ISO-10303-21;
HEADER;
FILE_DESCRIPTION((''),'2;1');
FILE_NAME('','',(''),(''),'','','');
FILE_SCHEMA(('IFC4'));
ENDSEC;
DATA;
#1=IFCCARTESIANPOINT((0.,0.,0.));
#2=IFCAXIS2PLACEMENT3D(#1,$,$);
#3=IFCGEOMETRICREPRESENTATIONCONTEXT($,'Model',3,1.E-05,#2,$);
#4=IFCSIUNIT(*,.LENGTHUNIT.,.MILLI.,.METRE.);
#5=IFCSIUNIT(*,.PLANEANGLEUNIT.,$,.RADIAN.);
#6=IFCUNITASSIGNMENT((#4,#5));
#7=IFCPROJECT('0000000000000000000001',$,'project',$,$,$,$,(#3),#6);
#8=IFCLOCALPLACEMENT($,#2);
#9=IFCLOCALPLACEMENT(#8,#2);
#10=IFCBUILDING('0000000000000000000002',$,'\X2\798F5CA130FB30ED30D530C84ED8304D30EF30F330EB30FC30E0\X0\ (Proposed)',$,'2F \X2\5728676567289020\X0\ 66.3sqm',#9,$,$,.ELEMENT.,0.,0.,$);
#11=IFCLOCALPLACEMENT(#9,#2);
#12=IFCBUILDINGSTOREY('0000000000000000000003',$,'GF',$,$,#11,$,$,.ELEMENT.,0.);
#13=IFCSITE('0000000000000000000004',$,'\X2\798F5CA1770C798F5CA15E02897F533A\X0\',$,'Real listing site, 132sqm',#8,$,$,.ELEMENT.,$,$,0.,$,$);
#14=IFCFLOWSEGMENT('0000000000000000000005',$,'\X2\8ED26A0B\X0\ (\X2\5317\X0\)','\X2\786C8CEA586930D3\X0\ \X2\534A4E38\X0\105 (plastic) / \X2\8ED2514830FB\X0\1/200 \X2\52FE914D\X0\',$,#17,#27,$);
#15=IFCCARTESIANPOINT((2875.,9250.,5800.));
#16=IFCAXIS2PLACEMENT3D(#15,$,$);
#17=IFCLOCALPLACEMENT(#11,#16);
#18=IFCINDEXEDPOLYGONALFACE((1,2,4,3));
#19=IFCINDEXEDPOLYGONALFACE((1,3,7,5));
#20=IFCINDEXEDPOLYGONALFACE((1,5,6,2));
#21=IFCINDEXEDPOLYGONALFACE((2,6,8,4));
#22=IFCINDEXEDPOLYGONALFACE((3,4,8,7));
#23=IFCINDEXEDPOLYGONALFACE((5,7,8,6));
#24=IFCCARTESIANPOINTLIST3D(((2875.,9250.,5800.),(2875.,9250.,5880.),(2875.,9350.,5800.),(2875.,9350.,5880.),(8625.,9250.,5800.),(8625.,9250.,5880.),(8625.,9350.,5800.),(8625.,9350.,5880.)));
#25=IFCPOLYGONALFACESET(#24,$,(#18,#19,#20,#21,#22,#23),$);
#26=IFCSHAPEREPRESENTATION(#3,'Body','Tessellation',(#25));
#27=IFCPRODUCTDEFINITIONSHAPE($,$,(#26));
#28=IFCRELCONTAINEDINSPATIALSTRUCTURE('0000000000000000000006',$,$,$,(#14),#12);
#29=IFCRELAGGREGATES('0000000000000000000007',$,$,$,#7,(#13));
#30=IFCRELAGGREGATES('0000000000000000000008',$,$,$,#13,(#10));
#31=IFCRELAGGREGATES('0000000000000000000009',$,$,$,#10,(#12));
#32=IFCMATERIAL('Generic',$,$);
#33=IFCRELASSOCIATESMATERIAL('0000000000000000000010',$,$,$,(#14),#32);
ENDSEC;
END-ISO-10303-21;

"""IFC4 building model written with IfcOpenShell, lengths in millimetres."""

from ifc_helpers import new_model, si_unit, frame, frame_2d, origin, place, context, project, spatial, rectangle, extrude, material, element, save


model = new_model("IFC4")

# Units and contexts
model_context = context("Model", 3, precision=1e-05, world=origin())
ifc_project = project(units=[si_unit("LENGTHUNIT", "METRE", prefix="MILLI"), si_unit("PLANEANGLEUNIT", "RADIAN")], contexts=[model_context])

# Site, building, storey
site_placement = place(None, origin())
site = spatial("IfcSite", under=ifc_project, at=site_placement, Name="福岡県福岡市西区", ObjectType="Real listing site, 132sqm", CompositionType="ELEMENT", RefElevation=0.0)
building_placement = place(site_placement, origin())
building = spatial("IfcBuilding", under=site, at=building_placement, Name="福岡・ロフト付きワンルーム (Proposed)", ObjectType="2F 在来木造 66.3sqm", CompositionType="ELEMENT", ElevationOfRefHeight=0.0, ElevationOfTerrain=0.0)
storey_placement = place(building_placement, origin())
storey = spatial("IfcBuildingStorey", under=building, at=storey_placement, Name="GF", CompositionType="ELEMENT", Elevation=0.0)

# Shared definitions
ifc_material_1 = material(Name="Generic")

# Flow segment
flow_segment_placement = place(storey_placement, frame((2875.0, 9250.0, 5800.0)))
element("IfcFlowSegment", 1, at=flow_segment_placement, inside=storey, material=ifc_material_1, Name="軒樋 (北)", Description="硬質塩ビ 半丸105 (plastic) / 軒先・1/200 勾配", context=model_context, shape_type="SweptSolid", body=[
    extrude(rectangle(XDim=5750.0, YDim=100.0, at=frame_2d((2875.0, 50.0))), frame((2875.0, 9250.0, 5800.0)), (0.0, 0.0, 1.0), 80.0),
])

save(model, "model.ifc")
